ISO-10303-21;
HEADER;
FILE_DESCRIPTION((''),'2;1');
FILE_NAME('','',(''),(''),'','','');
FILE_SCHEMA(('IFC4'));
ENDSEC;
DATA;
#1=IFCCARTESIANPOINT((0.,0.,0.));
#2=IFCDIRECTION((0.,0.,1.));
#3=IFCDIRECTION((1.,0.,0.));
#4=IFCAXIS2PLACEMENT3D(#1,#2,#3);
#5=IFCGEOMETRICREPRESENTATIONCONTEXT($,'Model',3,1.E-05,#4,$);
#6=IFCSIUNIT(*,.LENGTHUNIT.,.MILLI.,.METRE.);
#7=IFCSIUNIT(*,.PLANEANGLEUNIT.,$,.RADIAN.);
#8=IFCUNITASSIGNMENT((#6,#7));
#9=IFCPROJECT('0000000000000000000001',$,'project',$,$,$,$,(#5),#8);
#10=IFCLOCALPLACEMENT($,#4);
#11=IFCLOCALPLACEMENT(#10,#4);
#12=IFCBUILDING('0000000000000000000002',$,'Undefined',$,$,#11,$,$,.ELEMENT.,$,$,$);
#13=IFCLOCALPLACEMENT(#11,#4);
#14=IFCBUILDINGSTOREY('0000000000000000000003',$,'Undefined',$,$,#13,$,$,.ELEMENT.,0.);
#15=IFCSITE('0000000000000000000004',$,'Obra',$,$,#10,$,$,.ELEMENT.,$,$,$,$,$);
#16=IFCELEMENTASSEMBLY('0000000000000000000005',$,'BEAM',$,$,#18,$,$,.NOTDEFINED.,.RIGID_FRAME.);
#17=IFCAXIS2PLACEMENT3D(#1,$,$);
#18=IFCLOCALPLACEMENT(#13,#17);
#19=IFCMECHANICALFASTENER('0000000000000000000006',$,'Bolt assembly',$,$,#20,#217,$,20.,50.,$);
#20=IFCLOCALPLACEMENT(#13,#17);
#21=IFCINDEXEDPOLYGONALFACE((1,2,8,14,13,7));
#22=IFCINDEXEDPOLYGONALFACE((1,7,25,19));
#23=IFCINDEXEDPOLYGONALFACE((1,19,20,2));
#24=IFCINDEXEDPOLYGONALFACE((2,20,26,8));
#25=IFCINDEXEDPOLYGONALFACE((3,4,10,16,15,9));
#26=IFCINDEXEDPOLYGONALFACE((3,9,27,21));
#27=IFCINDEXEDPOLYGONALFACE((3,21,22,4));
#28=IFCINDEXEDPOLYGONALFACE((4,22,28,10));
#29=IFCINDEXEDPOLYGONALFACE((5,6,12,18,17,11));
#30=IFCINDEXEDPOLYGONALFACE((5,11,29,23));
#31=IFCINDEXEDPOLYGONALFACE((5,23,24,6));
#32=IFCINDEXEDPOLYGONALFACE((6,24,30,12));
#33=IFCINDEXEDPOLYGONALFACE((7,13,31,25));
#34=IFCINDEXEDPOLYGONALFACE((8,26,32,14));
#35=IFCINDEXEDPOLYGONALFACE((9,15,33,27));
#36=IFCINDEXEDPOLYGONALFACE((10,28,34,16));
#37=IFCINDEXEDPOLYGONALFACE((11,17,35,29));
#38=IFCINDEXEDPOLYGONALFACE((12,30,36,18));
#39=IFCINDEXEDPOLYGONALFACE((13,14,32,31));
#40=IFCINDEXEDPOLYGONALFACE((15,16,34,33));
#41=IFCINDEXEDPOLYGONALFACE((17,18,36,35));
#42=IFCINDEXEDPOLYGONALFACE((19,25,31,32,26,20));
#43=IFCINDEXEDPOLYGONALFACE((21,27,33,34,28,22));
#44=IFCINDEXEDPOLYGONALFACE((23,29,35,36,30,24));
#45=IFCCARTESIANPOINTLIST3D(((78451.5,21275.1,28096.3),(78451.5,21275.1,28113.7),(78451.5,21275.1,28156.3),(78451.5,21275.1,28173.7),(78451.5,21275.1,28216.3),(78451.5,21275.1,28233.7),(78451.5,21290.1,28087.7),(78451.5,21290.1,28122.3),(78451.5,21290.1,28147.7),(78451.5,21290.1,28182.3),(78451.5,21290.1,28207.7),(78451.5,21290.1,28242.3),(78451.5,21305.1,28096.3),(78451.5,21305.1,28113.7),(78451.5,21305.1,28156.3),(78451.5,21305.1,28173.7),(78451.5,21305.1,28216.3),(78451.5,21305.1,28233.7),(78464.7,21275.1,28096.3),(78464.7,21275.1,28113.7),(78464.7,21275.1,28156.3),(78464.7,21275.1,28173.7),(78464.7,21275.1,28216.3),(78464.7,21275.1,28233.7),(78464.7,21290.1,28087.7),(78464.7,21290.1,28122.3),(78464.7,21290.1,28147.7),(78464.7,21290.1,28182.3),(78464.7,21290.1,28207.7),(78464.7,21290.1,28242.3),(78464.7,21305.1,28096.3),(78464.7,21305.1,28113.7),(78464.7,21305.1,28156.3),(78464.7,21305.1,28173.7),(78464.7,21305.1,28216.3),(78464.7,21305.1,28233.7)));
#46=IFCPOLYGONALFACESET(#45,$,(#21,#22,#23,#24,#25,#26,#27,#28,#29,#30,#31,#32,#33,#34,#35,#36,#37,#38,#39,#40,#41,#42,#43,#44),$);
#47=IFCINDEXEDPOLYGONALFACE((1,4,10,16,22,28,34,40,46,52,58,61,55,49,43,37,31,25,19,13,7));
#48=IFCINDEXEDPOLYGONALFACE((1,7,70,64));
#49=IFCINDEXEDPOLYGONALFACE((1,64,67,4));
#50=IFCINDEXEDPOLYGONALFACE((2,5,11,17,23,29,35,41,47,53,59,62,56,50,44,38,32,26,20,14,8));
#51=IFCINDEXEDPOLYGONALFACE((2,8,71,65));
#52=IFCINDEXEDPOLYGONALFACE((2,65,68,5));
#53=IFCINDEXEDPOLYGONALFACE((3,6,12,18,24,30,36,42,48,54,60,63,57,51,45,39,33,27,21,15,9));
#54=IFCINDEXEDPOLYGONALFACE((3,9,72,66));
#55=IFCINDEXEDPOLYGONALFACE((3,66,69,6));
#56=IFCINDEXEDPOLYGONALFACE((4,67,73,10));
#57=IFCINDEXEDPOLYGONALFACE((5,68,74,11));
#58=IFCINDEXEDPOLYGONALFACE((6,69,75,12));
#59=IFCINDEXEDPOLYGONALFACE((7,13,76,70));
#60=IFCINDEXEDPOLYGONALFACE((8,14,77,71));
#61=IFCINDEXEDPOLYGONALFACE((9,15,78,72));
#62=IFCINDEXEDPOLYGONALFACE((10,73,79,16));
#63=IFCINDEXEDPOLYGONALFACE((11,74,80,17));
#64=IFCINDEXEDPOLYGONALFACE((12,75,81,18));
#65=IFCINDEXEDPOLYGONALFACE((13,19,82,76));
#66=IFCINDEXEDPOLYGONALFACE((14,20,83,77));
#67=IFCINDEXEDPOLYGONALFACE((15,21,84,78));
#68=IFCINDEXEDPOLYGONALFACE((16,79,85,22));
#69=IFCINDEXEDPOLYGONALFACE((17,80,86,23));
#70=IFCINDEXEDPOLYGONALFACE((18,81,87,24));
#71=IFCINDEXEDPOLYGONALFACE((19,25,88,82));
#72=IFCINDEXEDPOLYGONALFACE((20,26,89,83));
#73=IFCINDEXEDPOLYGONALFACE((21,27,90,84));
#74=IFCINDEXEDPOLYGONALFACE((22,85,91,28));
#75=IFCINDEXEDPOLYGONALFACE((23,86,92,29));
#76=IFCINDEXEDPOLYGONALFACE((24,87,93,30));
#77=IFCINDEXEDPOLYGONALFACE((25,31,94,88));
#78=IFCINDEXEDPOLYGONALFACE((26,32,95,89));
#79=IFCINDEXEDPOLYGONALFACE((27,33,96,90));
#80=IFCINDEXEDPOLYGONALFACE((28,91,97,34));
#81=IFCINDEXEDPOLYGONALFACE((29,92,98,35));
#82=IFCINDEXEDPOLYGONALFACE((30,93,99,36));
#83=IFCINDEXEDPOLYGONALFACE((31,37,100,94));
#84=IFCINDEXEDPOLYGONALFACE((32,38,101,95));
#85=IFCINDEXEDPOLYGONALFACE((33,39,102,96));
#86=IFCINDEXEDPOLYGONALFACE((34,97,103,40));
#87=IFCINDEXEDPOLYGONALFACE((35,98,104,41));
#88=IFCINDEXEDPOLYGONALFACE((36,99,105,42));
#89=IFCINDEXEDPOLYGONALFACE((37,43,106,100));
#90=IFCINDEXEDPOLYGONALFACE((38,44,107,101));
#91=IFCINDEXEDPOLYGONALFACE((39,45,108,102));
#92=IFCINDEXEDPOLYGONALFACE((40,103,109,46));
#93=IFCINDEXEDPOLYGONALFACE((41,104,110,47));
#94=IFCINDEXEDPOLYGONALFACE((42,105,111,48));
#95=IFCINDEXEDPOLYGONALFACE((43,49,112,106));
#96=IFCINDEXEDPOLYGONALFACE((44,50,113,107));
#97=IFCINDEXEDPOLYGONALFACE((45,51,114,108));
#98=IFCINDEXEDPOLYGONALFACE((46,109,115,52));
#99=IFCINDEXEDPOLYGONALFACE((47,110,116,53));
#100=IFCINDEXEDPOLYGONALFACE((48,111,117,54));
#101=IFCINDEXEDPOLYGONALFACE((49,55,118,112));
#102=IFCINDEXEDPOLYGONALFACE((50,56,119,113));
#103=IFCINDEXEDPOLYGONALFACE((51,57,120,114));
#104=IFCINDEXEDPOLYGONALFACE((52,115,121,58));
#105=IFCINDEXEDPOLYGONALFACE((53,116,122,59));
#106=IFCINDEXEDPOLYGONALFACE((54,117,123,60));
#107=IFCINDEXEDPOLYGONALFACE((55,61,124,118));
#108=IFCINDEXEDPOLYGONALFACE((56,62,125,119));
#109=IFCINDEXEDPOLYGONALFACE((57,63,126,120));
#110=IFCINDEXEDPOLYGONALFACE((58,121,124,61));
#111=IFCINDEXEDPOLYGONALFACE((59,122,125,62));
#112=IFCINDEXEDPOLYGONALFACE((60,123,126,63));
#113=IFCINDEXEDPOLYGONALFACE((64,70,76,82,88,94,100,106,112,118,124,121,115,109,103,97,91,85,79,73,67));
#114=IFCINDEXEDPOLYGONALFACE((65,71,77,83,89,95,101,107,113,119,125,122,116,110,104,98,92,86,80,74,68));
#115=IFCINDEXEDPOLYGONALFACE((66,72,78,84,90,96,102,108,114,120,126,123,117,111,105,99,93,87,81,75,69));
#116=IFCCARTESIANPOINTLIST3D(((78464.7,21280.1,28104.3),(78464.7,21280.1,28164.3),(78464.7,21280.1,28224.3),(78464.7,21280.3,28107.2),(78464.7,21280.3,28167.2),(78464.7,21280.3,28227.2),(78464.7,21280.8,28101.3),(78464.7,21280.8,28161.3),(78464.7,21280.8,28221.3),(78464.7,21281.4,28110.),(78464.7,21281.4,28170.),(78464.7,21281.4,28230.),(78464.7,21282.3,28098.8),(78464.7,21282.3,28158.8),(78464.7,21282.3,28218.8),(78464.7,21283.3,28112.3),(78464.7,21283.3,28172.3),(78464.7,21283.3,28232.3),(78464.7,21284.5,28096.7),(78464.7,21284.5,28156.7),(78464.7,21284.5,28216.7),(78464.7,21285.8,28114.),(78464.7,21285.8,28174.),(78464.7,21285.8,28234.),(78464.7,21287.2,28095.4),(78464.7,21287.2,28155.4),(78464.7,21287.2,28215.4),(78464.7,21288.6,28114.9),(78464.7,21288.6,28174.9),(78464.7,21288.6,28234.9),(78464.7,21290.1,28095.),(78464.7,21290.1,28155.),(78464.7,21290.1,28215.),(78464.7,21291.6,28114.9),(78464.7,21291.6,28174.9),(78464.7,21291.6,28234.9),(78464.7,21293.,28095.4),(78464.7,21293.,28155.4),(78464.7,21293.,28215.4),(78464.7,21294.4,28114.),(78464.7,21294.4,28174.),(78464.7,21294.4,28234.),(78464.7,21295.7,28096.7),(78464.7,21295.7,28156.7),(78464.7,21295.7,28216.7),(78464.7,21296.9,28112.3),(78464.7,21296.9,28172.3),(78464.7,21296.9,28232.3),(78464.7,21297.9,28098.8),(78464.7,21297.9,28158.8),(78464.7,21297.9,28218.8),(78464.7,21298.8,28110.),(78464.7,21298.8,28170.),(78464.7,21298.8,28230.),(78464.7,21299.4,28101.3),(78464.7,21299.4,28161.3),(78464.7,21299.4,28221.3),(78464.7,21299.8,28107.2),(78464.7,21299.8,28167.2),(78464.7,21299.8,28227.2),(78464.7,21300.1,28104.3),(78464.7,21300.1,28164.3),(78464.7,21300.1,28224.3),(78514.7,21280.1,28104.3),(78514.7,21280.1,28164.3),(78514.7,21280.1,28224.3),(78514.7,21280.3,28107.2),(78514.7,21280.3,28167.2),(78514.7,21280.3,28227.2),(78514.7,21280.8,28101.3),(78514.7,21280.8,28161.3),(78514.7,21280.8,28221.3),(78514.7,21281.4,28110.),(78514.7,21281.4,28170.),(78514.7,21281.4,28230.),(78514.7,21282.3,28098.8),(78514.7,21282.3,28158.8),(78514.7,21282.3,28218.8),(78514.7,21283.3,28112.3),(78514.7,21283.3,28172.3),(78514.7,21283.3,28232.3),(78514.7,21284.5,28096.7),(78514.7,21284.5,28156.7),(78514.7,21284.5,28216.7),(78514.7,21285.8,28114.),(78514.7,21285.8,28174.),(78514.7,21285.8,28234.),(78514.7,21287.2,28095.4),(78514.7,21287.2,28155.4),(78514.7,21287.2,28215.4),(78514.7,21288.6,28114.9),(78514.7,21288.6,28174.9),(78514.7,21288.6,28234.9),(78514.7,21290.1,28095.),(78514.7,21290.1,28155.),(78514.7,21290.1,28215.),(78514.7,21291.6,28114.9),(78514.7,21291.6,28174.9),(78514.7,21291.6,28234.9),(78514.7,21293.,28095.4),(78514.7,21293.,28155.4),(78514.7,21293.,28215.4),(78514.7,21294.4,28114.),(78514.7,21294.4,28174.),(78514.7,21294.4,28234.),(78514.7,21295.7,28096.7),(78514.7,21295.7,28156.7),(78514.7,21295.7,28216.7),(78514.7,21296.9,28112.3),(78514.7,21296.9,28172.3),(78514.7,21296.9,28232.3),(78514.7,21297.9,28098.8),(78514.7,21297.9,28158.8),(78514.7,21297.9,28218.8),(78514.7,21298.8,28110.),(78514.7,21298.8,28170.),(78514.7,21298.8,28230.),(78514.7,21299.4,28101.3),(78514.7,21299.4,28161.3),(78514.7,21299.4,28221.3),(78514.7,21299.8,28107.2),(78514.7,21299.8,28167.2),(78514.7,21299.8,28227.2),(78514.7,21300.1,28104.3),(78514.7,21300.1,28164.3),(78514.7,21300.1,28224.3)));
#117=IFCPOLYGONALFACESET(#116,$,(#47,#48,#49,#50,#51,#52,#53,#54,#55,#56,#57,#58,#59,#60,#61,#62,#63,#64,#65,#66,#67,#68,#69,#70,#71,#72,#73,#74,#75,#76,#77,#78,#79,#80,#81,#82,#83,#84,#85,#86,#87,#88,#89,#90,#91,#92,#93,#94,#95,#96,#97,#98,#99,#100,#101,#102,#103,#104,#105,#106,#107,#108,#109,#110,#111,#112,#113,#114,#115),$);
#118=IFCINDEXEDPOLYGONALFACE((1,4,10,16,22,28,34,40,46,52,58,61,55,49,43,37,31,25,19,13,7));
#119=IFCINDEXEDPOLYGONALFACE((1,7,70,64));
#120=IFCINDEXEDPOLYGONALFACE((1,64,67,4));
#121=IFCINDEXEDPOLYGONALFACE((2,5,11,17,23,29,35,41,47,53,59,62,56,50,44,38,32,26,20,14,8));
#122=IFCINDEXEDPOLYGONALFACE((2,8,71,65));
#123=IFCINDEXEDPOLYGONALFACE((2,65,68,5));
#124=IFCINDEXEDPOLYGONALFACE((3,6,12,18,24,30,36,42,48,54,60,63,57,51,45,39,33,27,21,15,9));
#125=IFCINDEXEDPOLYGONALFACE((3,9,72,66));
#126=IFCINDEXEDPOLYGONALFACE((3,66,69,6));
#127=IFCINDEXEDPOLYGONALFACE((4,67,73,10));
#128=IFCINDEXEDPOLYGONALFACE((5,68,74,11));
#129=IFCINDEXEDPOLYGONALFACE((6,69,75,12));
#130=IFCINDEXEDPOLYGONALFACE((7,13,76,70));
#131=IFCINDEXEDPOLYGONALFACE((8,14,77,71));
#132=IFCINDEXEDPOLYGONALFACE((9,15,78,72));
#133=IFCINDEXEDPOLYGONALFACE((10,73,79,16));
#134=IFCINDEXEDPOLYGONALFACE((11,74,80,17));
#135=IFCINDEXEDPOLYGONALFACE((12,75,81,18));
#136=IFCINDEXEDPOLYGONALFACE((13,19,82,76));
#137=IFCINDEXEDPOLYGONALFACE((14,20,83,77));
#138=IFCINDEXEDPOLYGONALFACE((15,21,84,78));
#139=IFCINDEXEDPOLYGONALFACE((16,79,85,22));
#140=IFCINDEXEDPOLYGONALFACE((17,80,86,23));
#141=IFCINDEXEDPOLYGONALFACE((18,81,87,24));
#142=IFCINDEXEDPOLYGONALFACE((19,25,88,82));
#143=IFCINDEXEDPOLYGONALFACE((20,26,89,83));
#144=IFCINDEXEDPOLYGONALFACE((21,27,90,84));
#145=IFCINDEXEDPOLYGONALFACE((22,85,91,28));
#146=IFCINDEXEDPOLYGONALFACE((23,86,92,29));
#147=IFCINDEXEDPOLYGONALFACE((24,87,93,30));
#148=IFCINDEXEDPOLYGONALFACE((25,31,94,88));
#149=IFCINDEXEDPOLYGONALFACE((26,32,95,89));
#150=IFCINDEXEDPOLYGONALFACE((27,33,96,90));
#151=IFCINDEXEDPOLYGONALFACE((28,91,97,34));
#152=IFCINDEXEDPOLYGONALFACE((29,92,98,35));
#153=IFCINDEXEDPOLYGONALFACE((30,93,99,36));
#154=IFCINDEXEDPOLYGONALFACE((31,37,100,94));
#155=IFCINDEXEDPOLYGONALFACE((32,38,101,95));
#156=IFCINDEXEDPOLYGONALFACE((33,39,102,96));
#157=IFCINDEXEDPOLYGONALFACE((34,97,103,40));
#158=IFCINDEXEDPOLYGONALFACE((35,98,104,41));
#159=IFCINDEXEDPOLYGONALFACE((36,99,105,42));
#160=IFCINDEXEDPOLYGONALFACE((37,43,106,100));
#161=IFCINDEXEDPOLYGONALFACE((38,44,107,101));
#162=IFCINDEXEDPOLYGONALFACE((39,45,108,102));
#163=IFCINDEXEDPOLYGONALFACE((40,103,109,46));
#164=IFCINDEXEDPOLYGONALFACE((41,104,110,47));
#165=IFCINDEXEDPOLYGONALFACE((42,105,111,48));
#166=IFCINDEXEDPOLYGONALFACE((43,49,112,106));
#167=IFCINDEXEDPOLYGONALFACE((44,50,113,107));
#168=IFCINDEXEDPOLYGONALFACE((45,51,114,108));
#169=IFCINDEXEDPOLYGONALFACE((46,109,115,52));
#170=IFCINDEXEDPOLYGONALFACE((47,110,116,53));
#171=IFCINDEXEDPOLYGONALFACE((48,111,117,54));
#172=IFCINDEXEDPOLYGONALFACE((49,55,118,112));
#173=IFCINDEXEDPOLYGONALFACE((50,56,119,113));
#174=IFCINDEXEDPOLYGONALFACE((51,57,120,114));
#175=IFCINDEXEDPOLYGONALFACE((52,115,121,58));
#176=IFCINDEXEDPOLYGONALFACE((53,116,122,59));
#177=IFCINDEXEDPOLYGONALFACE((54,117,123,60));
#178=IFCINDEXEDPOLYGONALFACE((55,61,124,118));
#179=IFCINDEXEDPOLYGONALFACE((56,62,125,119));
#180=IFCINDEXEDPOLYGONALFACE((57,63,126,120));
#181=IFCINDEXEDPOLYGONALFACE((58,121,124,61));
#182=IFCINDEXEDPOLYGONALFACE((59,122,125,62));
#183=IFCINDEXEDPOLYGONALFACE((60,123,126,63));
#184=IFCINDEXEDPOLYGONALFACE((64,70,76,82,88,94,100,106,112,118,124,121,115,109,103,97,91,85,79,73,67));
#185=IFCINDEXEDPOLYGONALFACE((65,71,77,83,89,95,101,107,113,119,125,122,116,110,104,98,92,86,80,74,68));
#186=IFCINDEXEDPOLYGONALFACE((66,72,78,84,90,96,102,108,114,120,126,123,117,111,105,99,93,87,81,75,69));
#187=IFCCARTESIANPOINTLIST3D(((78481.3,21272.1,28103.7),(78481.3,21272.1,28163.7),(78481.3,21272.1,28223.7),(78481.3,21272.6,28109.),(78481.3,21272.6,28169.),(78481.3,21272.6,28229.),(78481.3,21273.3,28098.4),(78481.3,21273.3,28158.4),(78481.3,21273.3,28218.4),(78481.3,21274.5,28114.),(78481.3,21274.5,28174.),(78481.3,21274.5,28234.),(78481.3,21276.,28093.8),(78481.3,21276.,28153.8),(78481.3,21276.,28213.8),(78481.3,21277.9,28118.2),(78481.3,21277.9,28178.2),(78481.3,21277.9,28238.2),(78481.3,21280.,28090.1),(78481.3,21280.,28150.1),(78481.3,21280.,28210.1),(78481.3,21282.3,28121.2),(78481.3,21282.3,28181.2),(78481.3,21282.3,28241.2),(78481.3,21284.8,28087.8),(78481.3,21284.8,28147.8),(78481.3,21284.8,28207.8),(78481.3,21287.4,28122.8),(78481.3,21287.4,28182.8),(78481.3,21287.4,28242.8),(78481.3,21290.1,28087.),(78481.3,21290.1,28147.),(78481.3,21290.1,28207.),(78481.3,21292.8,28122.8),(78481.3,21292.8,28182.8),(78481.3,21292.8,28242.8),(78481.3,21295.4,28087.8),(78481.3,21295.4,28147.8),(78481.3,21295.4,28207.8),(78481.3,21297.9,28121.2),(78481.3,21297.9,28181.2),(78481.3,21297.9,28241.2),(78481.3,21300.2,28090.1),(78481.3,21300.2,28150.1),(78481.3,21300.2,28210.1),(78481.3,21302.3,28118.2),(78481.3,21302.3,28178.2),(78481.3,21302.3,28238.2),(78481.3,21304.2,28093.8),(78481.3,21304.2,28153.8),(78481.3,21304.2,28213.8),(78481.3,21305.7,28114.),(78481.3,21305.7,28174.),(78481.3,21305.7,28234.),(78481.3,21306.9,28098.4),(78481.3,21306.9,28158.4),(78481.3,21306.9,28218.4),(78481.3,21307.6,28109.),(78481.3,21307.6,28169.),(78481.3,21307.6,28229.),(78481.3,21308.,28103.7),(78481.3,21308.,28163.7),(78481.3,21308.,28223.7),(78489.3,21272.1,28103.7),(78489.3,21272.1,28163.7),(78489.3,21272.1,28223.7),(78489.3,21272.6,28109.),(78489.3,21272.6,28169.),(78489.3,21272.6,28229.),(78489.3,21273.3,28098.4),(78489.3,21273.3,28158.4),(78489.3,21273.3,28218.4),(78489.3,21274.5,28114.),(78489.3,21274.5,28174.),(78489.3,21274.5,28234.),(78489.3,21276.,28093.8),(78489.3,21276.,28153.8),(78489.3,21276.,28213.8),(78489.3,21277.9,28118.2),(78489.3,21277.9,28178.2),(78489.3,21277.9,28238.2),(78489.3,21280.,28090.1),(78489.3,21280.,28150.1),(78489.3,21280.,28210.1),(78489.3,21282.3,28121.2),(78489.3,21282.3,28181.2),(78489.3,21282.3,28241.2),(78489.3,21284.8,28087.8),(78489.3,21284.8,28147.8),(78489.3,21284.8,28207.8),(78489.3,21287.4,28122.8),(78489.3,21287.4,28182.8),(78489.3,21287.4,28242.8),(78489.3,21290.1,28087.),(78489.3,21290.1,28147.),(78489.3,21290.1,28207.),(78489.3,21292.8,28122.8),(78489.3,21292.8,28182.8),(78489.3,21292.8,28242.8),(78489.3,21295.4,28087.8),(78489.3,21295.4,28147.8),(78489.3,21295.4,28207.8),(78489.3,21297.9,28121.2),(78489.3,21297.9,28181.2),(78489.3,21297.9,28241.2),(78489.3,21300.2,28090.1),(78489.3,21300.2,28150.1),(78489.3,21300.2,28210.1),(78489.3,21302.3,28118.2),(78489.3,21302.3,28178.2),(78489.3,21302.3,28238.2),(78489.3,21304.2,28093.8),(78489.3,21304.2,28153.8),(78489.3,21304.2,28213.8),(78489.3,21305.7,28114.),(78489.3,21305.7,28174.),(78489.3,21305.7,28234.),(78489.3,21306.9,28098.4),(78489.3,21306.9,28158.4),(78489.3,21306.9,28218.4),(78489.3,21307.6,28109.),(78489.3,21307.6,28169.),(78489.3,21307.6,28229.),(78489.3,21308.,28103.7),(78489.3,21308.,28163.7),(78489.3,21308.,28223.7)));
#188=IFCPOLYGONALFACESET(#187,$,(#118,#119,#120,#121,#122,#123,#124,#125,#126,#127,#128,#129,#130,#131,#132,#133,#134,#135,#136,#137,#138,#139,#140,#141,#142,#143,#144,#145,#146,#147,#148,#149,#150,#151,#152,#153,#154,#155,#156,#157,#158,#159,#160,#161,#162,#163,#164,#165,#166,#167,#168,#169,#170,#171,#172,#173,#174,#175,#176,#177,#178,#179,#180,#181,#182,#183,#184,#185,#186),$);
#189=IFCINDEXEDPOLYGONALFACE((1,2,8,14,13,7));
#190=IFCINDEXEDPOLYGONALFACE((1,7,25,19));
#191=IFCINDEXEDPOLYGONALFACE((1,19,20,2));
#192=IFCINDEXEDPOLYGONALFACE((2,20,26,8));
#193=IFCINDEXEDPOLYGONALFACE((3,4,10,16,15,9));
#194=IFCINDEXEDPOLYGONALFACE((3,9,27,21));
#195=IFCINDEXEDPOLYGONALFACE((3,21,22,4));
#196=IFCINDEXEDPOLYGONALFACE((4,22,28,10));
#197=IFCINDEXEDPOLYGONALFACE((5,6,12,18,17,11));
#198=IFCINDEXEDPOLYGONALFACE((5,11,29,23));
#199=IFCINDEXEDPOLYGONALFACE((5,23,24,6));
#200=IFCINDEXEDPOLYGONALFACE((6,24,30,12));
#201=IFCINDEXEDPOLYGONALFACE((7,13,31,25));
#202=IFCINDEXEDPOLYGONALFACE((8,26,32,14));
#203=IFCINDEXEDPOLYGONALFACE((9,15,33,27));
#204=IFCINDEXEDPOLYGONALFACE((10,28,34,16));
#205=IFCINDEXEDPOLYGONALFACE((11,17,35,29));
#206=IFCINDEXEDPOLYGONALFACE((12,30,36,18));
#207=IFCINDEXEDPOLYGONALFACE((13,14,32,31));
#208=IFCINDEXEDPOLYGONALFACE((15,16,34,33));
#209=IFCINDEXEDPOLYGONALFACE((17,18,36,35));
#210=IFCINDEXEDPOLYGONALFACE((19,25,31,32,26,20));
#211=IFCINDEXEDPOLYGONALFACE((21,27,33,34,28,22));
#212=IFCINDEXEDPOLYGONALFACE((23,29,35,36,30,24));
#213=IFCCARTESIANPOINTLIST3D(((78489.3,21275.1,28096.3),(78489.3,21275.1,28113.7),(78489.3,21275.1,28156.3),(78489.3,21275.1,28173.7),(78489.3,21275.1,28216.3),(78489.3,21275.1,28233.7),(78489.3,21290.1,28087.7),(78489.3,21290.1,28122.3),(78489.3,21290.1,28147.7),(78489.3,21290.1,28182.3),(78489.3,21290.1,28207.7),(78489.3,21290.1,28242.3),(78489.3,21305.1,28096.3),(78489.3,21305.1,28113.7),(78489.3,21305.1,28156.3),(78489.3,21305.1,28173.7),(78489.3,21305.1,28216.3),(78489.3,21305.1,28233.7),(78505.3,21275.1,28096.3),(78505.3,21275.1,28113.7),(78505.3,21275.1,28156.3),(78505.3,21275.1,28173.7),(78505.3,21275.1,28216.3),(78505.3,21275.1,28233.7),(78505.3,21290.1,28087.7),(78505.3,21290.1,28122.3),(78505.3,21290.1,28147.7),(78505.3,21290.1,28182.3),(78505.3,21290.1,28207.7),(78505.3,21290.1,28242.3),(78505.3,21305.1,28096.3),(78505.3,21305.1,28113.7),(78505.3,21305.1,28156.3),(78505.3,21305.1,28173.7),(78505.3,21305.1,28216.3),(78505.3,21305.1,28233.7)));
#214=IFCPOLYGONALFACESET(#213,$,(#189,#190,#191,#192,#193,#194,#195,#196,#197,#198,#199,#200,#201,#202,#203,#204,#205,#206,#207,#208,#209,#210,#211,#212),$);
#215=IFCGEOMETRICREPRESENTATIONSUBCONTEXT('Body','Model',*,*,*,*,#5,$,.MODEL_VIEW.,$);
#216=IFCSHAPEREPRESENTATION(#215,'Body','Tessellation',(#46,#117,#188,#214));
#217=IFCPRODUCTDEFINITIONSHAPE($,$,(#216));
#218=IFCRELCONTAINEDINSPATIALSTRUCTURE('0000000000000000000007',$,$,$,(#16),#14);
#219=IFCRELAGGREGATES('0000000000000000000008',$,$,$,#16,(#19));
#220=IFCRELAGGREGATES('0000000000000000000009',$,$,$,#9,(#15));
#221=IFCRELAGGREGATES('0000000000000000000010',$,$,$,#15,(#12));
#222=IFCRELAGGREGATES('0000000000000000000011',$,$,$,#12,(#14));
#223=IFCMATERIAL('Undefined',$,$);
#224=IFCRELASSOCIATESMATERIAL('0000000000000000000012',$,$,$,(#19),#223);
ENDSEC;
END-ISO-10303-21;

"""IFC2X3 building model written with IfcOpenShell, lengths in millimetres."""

from ifc_helpers import new_model, si_unit, frame, origin_with_axes, origin_2d_with_axis, place, context, subcontext, project, spatial, polyline, circle, outline, extrude, source, transform, mapped, material, element, aggregate, save


model = new_model("IFC2X3")

# Units and contexts
model_context = context("Model", 3, precision=1e-05, world=origin_with_axes())
body_context = subcontext(model_context, "Body", "Model", "MODEL_VIEW")
ifc_project = project(units=[si_unit("LENGTHUNIT", "METRE", prefix="MILLI"), si_unit("PLANEANGLEUNIT", "RADIAN")], contexts=[model_context])

# Site, building, storey
site_placement = place(None, origin_with_axes())
site = spatial("IfcSite", under=ifc_project, at=site_placement, Name="Obra", CompositionType="ELEMENT")
building_placement = place(site_placement, origin_with_axes())
building = spatial("IfcBuilding", under=site, at=building_placement, Name="Undefined", CompositionType="ELEMENT")
storey_placement = place(building_placement, origin_with_axes())
storey = spatial("IfcBuildingStorey", under=building, at=storey_placement, Name="Undefined", CompositionType="ELEMENT", Elevation=0.0)

# Element assembly
assembly_1_placement = place(storey_placement, origin_with_axes())
assembly_1 = element("IfcElementAssembly", 1, at=assembly_1_placement, inside=storey, Name="BEAM", AssemblyPlace="NOTDEFINED", PredefinedType="RIGID_FRAME")

# Shared definitions
ifc_material_1 = material(Name="Undefined")
shared_shape_1 = source(origin_with_axes(), body_context, "Body", "SweptSolid", [
    extrude(outline(polyline([(17.3, 0.0), (8.7, 15.0), (-8.7, 15.0), (-17.3, 0.0), (-8.7, -15.0), (8.7, -15.0), (17.3, 0.0)])), frame((0.0, -26.5, 0.0), z_axis=(0.0, 1.0, 0.0), x_axis=(1.0, 0.0, 0.0)), (0.0, 0.0, 1.0), 13.2),
    extrude(circle(Radius=10.0, at=origin_2d_with_axis()), frame((0.0, -13.3, 0.0), z_axis=(0.0, 1.0, 0.0), x_axis=(1.0, 0.0, 0.0)), (0.0, 0.0, 1.0), 50.0),
    extrude(circle(Radius=18.0, at=origin_2d_with_axis()), frame((0.0, 3.3, 0.0), z_axis=(0.0, 1.0, 0.0), x_axis=(1.0, 0.0, 0.0)), (0.0, 0.0, 1.0), 8.0),
    extrude(outline(polyline([(17.3, 0.0), (8.7, 15.0), (-8.7, 15.0), (-17.3, 0.0), (-8.7, -15.0), (8.7, -15.0), (17.3, 0.0)])), frame((0.0, 11.3, 0.0), z_axis=(0.0, 1.0, 0.0), x_axis=(1.0, 0.0, 0.0)), (0.0, 0.0, 1.0), 16.0),
])

# Mechanical fastener
mechanical_fastener_1_placement = place(assembly_1_placement, frame((78478.0, 21340.1, 28265.0), z_axis=(0.0, -1.0, 0.0), x_axis=(0.0, 0.0, -1.0)))
mechanical_fastener_1 = element("IfcMechanicalFastener", 2, at=mechanical_fastener_1_placement, material=ifc_material_1, Name="Bolt assembly", NominalDiameter=20.0, NominalLength=50.0, context=body_context, shape_type="MappedRepresentation", body=[
    mapped(shared_shape_1, transform((40.0, 0.0, 50.0))),
    mapped(shared_shape_1, transform((100.0, 0.0, 50.0))),
    mapped(shared_shape_1, transform((160.0, 0.0, 50.0))),
])
aggregate(assembly_1, [mechanical_fastener_1])

save(model, "model.ifc")
